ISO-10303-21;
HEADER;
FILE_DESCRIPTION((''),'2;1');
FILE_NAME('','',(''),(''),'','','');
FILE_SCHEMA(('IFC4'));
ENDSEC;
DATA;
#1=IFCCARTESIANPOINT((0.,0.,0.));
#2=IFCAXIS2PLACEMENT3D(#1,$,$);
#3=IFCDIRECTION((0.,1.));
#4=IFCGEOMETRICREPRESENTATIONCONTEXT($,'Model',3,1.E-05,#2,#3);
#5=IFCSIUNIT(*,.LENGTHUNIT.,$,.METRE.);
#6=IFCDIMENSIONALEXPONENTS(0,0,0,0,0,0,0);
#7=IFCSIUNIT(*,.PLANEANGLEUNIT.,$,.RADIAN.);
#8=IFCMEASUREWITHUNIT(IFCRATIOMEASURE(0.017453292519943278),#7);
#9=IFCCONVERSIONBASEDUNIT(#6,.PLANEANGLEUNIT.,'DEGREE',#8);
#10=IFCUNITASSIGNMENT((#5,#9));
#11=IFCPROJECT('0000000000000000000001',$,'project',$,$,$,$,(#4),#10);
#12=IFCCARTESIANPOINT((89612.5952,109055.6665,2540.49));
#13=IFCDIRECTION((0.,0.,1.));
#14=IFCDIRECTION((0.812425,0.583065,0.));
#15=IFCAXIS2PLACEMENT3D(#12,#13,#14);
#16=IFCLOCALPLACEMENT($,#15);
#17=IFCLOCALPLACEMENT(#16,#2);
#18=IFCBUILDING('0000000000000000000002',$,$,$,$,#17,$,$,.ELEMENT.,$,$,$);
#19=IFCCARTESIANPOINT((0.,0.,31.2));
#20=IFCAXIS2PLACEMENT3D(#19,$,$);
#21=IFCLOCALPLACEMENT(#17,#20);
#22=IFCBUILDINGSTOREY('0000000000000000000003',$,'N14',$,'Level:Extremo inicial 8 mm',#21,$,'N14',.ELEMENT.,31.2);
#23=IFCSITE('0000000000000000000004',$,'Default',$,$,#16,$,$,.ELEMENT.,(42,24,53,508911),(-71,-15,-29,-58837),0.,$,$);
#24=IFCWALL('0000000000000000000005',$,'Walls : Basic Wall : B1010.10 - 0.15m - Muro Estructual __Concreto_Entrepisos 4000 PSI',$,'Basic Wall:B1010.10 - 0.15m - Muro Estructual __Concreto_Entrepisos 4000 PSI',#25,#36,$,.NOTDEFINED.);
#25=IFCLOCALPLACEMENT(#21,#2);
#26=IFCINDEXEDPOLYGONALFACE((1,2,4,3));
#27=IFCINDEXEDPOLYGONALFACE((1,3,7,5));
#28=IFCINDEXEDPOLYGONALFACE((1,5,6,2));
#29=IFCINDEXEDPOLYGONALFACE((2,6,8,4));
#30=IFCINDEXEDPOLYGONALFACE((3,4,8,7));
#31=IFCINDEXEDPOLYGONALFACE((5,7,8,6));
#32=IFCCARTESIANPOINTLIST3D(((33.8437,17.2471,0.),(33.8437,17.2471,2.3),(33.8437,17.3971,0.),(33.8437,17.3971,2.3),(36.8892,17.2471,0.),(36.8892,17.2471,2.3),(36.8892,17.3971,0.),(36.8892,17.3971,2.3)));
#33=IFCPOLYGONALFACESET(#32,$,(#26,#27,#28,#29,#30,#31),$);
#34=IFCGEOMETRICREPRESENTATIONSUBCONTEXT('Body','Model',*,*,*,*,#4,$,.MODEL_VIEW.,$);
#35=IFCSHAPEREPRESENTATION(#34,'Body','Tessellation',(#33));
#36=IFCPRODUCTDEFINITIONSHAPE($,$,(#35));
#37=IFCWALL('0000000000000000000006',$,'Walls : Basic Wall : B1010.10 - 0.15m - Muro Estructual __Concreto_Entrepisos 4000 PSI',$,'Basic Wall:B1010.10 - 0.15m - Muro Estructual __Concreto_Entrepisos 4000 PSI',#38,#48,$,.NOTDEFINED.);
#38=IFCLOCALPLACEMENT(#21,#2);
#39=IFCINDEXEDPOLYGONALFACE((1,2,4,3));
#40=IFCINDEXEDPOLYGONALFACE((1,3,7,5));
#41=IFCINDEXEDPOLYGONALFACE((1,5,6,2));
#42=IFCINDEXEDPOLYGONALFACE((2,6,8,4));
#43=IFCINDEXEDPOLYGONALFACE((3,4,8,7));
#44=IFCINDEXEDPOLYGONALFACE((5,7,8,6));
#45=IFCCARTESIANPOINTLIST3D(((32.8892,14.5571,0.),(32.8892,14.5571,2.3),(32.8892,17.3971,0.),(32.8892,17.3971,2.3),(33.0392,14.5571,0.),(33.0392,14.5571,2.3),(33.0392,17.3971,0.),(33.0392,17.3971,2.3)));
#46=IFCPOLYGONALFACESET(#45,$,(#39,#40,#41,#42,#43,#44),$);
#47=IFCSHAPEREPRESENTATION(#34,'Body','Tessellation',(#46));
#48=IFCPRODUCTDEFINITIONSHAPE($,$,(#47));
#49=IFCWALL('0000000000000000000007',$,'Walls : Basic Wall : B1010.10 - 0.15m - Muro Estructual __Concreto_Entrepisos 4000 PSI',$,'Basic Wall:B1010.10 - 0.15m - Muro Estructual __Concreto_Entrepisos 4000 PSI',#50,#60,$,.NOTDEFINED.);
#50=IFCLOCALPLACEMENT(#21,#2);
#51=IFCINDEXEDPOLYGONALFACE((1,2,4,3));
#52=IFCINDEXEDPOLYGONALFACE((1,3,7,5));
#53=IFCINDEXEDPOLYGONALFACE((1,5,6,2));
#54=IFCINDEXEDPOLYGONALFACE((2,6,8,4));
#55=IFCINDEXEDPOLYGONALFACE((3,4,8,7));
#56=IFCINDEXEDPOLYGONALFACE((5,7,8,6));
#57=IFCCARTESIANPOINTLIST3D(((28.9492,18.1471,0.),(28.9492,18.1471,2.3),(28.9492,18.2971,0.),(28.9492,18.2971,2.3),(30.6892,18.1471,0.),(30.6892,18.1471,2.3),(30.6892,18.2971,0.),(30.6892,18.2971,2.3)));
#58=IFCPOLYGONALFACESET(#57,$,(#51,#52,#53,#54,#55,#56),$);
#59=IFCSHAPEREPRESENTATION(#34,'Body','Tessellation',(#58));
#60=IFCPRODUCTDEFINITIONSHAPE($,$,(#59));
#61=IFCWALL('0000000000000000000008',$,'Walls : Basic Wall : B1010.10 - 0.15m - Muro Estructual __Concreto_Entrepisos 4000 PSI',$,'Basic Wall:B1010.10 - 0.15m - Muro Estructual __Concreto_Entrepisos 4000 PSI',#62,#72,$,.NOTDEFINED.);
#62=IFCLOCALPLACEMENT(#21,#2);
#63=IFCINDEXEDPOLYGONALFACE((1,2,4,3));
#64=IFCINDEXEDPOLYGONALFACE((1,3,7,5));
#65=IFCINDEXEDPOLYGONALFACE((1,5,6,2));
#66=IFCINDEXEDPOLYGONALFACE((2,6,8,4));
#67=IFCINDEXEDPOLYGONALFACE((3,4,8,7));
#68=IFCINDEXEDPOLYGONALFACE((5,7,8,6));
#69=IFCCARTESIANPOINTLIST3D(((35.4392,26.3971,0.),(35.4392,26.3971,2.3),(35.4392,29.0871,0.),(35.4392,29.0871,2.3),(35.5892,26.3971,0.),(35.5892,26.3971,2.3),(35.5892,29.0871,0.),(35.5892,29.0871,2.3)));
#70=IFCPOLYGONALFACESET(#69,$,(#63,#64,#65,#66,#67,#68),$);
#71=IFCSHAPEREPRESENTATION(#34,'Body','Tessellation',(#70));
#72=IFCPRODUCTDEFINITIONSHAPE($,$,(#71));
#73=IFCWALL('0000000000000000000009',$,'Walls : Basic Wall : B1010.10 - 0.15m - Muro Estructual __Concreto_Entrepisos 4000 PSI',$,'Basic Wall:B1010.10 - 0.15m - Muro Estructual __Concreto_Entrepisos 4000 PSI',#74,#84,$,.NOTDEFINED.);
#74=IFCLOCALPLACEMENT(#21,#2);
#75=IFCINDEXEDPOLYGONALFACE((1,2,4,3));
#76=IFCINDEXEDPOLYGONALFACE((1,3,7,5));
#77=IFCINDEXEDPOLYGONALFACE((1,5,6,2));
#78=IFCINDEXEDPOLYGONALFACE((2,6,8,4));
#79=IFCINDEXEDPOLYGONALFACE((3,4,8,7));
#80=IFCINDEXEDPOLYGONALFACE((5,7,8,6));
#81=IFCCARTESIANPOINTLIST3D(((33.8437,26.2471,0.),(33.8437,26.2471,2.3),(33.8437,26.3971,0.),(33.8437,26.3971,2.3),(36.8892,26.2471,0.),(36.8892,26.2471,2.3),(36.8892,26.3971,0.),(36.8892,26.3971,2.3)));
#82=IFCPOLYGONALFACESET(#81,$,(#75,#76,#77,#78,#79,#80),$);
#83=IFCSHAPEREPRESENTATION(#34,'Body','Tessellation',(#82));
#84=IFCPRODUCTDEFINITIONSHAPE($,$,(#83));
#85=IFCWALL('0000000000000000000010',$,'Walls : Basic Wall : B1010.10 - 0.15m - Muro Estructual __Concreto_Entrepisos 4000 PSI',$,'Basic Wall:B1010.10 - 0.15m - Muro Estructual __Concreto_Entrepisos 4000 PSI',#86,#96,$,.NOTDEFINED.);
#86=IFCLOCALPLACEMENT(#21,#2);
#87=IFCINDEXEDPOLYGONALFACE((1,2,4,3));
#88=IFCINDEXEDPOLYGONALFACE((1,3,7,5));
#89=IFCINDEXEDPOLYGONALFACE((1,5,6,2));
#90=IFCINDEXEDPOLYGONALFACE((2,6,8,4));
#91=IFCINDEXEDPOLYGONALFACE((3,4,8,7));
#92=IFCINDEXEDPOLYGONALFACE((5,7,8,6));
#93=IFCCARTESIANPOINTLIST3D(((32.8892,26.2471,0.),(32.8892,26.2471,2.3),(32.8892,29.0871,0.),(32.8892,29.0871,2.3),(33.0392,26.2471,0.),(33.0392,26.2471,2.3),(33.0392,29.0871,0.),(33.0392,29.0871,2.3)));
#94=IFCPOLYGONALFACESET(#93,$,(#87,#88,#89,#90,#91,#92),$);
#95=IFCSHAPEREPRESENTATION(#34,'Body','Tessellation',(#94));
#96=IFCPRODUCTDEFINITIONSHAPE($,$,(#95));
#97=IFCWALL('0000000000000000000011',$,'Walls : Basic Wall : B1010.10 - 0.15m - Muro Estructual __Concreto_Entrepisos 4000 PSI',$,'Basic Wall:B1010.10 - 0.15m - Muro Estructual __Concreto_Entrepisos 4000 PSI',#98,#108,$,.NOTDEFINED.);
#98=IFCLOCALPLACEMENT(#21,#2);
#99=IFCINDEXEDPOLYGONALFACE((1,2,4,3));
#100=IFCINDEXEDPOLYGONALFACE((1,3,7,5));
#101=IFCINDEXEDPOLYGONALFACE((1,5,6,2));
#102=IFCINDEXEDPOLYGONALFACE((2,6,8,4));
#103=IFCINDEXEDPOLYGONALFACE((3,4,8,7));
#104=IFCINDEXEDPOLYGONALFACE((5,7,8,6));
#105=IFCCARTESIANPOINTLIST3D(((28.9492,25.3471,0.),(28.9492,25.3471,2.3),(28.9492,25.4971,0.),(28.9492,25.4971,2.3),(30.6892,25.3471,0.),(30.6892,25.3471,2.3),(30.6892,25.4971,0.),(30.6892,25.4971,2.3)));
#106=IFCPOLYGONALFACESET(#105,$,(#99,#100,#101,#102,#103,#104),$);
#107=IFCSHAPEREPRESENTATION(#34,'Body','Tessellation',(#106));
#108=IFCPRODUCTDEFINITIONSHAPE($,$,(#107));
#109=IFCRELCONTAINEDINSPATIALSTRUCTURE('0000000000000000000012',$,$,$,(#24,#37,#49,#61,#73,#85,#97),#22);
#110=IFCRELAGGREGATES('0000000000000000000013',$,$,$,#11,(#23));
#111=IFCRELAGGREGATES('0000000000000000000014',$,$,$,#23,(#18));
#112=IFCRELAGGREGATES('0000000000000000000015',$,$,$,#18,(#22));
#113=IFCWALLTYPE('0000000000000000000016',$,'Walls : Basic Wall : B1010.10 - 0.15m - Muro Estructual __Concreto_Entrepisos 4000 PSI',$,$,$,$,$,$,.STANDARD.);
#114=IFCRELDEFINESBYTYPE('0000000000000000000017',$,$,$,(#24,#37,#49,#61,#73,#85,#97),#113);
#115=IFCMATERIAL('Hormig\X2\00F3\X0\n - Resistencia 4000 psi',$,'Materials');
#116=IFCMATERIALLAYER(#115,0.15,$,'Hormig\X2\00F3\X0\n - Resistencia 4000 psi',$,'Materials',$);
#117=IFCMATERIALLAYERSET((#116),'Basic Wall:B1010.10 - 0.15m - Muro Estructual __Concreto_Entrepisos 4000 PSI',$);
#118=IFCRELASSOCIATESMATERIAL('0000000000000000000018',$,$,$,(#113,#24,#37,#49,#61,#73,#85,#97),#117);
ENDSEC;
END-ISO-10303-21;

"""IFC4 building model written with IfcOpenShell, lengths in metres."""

from ifc_helpers import new_model, entity, si_unit, converted_unit, direction, frame, frame_2d, origin, place, context, subcontext, project, spatial, rectangle, extrude, material, layer, layer_set, layer_usage, type_object, element, save


model = new_model("IFC4")

# Units and contexts
model_context = context("Model", 3, precision=1e-05, world=origin(), true_north=direction((0.0, 1.0)))
body_context = subcontext(model_context, "Body", "Model", "MODEL_VIEW")
ifc_project = project(units=[si_unit("LENGTHUNIT", "METRE"), converted_unit("PLANEANGLEUNIT", "DEGREE", entity("IfcRatioMeasure", 0.017453292519943278), si_unit("PLANEANGLEUNIT", "RADIAN"), dimensions=[0, 0, 0, 0, 0, 0, 0])], contexts=[model_context])

# Site, building, storey
site_placement = place(None, frame((89612.5952, 109055.6665, 2540.49), z_axis=(0.0, 0.0, 1.0), x_axis=(0.812425, 0.583065, 0.0)))
site = spatial("IfcSite", under=ifc_project, at=site_placement, Name="Default", CompositionType="ELEMENT", RefLatitude=(42, 24, 53, 508911), RefLongitude=(-71, -15, -29, -58837), RefElevation=0.0)
building_placement = place(site_placement, origin())
building = spatial("IfcBuilding", under=site, at=building_placement, CompositionType="ELEMENT")
storey_placement = place(building_placement, frame((0.0, 0.0, 31.2)))
storey = spatial("IfcBuildingStorey", under=building, at=storey_placement, Name="N14", ObjectType="Level:Extremo inicial 8 mm", LongName="N14", CompositionType="ELEMENT", Elevation=31.2)

# Walls
ifc_material = material(Name="Hormigón - Resistencia 4000 psi", Category="Materials")
ifc_layer_1 = layer(ifc_material, 0.15, Name="Hormigón - Resistencia 4000 psi", Category="Materials")
ifc_layer_set_1 = layer_set([ifc_layer_1], Name="Basic Wall:B1010.10 - 0.15m - Muro Estructual __Concreto_Entrepisos 4000 PSI")
wall_type_1 = type_object("IfcWallType", Name="Walls : Basic Wall : B1010.10 - 0.15m - Muro Estructual __Concreto_Entrepisos 4000 PSI", PredefinedType="STANDARD", material=ifc_layer_set_1)
ifc_layer_usage_1 = layer_usage(ifc_layer_set_1, "AXIS2", "NEGATIVE", 0.075)
wall_1_placement = place(storey_placement, frame((36.8892, 17.3221, 0.0), z_axis=(0.0, 0.0, 1.0), x_axis=(-1.0, 0.0, 0.0)))
element("IfcWall", 1, at=wall_1_placement, inside=storey, type_object=wall_type_1, material=ifc_layer_usage_1, Name="Walls : Basic Wall : B1010.10 - 0.15m - Muro Estructual __Concreto_Entrepisos 4000 PSI", ObjectType="Basic Wall:B1010.10 - 0.15m - Muro Estructual __Concreto_Entrepisos 4000 PSI", PredefinedType="NOTDEFINED", context=body_context, shape_type="SweptSolid", body=[
    extrude(rectangle(XDim=3.0455, YDim=0.15, at=frame_2d((1.5228, 0.0), x_axis=(-1.0, 0.0))), origin(), (0.0, 0.0, 1.0), 2.3),
])
ifc_layer_usage_2 = layer_usage(ifc_layer_set_1, "AXIS2", "NEGATIVE", 0.075)
wall_2_placement = place(storey_placement, frame((32.9642, 14.5571, 0.0), z_axis=(0.0, 0.0, 1.0), x_axis=(0.0, 1.0, 0.0)))
element("IfcWall", 2, at=wall_2_placement, inside=storey, type_object=wall_type_1, material=ifc_layer_usage_2, Name="Walls : Basic Wall : B1010.10 - 0.15m - Muro Estructual __Concreto_Entrepisos 4000 PSI", ObjectType="Basic Wall:B1010.10 - 0.15m - Muro Estructual __Concreto_Entrepisos 4000 PSI", PredefinedType="NOTDEFINED", context=body_context, shape_type="SweptSolid", body=[
    extrude(rectangle(XDim=2.84, YDim=0.15, at=frame_2d((1.42, 0.0), x_axis=(-1.0, 0.0))), origin(), (0.0, 0.0, 1.0), 2.3),
])
ifc_layer_usage_3 = layer_usage(ifc_layer_set_1, "AXIS2", "NEGATIVE", 0.075)
wall_3_placement = place(storey_placement, frame((30.6892, 18.2221, 0.0), z_axis=(0.0, 0.0, 1.0), x_axis=(-1.0, 0.0, 0.0)))
element("IfcWall", 3, at=wall_3_placement, inside=storey, type_object=wall_type_1, material=ifc_layer_usage_3, Name="Walls : Basic Wall : B1010.10 - 0.15m - Muro Estructual __Concreto_Entrepisos 4000 PSI", ObjectType="Basic Wall:B1010.10 - 0.15m - Muro Estructual __Concreto_Entrepisos 4000 PSI", PredefinedType="NOTDEFINED", context=body_context, shape_type="SweptSolid", body=[
    extrude(rectangle(XDim=1.74, YDim=0.15, at=frame_2d((0.87, 0.0), x_axis=(-1.0, 0.0))), origin(), (0.0, 0.0, 1.0), 2.3),
])
ifc_layer_usage_4 = layer_usage(ifc_layer_set_1, "AXIS2", "POSITIVE", -0.075)
wall_4_placement = place(storey_placement, frame((35.5142, 29.0871, 0.0), z_axis=(0.0, 0.0, 1.0), x_axis=(0.0, -1.0, 0.0)))
element("IfcWall", 4, at=wall_4_placement, inside=storey, type_object=wall_type_1, material=ifc_layer_usage_4, Name="Walls : Basic Wall : B1010.10 - 0.15m - Muro Estructual __Concreto_Entrepisos 4000 PSI", ObjectType="Basic Wall:B1010.10 - 0.15m - Muro Estructual __Concreto_Entrepisos 4000 PSI", PredefinedType="NOTDEFINED", context=body_context, shape_type="SweptSolid", body=[
    extrude(rectangle(XDim=2.69, YDim=0.15, at=frame_2d((1.345, 0.0), x_axis=(-1.0, 0.0))), origin(), (0.0, 0.0, 1.0), 2.3),
])
ifc_layer_usage_5 = layer_usage(ifc_layer_set_1, "AXIS2", "POSITIVE", -0.075)
wall_5_placement = place(storey_placement, frame((36.8892, 26.3221, 0.0), z_axis=(0.0, 0.0, 1.0), x_axis=(-1.0, 0.0, 0.0)))
element("IfcWall", 5, at=wall_5_placement, inside=storey, type_object=wall_type_1, material=ifc_layer_usage_5, Name="Walls : Basic Wall : B1010.10 - 0.15m - Muro Estructual __Concreto_Entrepisos 4000 PSI", ObjectType="Basic Wall:B1010.10 - 0.15m - Muro Estructual __Concreto_Entrepisos 4000 PSI", PredefinedType="NOTDEFINED", context=body_context, shape_type="SweptSolid", body=[
    extrude(rectangle(XDim=3.0455, YDim=0.15, at=frame_2d((1.5228, 0.0), x_axis=(-1.0, 0.0))), origin(), (0.0, 0.0, 1.0), 2.3),
])
ifc_layer_usage_6 = layer_usage(ifc_layer_set_1, "AXIS2", "POSITIVE", -0.075)
wall_6_placement = place(storey_placement, frame((32.9642, 29.0871, 0.0), z_axis=(0.0, 0.0, 1.0), x_axis=(0.0, -1.0, 0.0)))
element("IfcWall", 6, at=wall_6_placement, inside=storey, type_object=wall_type_1, material=ifc_layer_usage_6, Name="Walls : Basic Wall : B1010.10 - 0.15m - Muro Estructual __Concreto_Entrepisos 4000 PSI", ObjectType="Basic Wall:B1010.10 - 0.15m - Muro Estructual __Concreto_Entrepisos 4000 PSI", PredefinedType="NOTDEFINED", context=body_context, shape_type="SweptSolid", body=[
    extrude(rectangle(XDim=2.84, YDim=0.15, at=frame_2d((1.42, 0.0), x_axis=(-1.0, 0.0))), origin(), (0.0, 0.0, 1.0), 2.3),
])
ifc_layer_usage_7 = layer_usage(ifc_layer_set_1, "AXIS2", "POSITIVE", -0.075)
wall_7_placement = place(storey_placement, frame((30.6892, 25.4221, 0.0), z_axis=(0.0, 0.0, 1.0), x_axis=(-1.0, 0.0, 0.0)))
element("IfcWall", 7, at=wall_7_placement, inside=storey, type_object=wall_type_1, material=ifc_layer_usage_7, Name="Walls : Basic Wall : B1010.10 - 0.15m - Muro Estructual __Concreto_Entrepisos 4000 PSI", ObjectType="Basic Wall:B1010.10 - 0.15m - Muro Estructual __Concreto_Entrepisos 4000 PSI", PredefinedType="NOTDEFINED", context=body_context, shape_type="SweptSolid", body=[
    extrude(rectangle(XDim=1.74, YDim=0.15, at=frame_2d((0.87, 0.0), x_axis=(-1.0, 0.0))), origin(), (0.0, 0.0, 1.0), 2.3),
])

save(model, "model.ifc")
